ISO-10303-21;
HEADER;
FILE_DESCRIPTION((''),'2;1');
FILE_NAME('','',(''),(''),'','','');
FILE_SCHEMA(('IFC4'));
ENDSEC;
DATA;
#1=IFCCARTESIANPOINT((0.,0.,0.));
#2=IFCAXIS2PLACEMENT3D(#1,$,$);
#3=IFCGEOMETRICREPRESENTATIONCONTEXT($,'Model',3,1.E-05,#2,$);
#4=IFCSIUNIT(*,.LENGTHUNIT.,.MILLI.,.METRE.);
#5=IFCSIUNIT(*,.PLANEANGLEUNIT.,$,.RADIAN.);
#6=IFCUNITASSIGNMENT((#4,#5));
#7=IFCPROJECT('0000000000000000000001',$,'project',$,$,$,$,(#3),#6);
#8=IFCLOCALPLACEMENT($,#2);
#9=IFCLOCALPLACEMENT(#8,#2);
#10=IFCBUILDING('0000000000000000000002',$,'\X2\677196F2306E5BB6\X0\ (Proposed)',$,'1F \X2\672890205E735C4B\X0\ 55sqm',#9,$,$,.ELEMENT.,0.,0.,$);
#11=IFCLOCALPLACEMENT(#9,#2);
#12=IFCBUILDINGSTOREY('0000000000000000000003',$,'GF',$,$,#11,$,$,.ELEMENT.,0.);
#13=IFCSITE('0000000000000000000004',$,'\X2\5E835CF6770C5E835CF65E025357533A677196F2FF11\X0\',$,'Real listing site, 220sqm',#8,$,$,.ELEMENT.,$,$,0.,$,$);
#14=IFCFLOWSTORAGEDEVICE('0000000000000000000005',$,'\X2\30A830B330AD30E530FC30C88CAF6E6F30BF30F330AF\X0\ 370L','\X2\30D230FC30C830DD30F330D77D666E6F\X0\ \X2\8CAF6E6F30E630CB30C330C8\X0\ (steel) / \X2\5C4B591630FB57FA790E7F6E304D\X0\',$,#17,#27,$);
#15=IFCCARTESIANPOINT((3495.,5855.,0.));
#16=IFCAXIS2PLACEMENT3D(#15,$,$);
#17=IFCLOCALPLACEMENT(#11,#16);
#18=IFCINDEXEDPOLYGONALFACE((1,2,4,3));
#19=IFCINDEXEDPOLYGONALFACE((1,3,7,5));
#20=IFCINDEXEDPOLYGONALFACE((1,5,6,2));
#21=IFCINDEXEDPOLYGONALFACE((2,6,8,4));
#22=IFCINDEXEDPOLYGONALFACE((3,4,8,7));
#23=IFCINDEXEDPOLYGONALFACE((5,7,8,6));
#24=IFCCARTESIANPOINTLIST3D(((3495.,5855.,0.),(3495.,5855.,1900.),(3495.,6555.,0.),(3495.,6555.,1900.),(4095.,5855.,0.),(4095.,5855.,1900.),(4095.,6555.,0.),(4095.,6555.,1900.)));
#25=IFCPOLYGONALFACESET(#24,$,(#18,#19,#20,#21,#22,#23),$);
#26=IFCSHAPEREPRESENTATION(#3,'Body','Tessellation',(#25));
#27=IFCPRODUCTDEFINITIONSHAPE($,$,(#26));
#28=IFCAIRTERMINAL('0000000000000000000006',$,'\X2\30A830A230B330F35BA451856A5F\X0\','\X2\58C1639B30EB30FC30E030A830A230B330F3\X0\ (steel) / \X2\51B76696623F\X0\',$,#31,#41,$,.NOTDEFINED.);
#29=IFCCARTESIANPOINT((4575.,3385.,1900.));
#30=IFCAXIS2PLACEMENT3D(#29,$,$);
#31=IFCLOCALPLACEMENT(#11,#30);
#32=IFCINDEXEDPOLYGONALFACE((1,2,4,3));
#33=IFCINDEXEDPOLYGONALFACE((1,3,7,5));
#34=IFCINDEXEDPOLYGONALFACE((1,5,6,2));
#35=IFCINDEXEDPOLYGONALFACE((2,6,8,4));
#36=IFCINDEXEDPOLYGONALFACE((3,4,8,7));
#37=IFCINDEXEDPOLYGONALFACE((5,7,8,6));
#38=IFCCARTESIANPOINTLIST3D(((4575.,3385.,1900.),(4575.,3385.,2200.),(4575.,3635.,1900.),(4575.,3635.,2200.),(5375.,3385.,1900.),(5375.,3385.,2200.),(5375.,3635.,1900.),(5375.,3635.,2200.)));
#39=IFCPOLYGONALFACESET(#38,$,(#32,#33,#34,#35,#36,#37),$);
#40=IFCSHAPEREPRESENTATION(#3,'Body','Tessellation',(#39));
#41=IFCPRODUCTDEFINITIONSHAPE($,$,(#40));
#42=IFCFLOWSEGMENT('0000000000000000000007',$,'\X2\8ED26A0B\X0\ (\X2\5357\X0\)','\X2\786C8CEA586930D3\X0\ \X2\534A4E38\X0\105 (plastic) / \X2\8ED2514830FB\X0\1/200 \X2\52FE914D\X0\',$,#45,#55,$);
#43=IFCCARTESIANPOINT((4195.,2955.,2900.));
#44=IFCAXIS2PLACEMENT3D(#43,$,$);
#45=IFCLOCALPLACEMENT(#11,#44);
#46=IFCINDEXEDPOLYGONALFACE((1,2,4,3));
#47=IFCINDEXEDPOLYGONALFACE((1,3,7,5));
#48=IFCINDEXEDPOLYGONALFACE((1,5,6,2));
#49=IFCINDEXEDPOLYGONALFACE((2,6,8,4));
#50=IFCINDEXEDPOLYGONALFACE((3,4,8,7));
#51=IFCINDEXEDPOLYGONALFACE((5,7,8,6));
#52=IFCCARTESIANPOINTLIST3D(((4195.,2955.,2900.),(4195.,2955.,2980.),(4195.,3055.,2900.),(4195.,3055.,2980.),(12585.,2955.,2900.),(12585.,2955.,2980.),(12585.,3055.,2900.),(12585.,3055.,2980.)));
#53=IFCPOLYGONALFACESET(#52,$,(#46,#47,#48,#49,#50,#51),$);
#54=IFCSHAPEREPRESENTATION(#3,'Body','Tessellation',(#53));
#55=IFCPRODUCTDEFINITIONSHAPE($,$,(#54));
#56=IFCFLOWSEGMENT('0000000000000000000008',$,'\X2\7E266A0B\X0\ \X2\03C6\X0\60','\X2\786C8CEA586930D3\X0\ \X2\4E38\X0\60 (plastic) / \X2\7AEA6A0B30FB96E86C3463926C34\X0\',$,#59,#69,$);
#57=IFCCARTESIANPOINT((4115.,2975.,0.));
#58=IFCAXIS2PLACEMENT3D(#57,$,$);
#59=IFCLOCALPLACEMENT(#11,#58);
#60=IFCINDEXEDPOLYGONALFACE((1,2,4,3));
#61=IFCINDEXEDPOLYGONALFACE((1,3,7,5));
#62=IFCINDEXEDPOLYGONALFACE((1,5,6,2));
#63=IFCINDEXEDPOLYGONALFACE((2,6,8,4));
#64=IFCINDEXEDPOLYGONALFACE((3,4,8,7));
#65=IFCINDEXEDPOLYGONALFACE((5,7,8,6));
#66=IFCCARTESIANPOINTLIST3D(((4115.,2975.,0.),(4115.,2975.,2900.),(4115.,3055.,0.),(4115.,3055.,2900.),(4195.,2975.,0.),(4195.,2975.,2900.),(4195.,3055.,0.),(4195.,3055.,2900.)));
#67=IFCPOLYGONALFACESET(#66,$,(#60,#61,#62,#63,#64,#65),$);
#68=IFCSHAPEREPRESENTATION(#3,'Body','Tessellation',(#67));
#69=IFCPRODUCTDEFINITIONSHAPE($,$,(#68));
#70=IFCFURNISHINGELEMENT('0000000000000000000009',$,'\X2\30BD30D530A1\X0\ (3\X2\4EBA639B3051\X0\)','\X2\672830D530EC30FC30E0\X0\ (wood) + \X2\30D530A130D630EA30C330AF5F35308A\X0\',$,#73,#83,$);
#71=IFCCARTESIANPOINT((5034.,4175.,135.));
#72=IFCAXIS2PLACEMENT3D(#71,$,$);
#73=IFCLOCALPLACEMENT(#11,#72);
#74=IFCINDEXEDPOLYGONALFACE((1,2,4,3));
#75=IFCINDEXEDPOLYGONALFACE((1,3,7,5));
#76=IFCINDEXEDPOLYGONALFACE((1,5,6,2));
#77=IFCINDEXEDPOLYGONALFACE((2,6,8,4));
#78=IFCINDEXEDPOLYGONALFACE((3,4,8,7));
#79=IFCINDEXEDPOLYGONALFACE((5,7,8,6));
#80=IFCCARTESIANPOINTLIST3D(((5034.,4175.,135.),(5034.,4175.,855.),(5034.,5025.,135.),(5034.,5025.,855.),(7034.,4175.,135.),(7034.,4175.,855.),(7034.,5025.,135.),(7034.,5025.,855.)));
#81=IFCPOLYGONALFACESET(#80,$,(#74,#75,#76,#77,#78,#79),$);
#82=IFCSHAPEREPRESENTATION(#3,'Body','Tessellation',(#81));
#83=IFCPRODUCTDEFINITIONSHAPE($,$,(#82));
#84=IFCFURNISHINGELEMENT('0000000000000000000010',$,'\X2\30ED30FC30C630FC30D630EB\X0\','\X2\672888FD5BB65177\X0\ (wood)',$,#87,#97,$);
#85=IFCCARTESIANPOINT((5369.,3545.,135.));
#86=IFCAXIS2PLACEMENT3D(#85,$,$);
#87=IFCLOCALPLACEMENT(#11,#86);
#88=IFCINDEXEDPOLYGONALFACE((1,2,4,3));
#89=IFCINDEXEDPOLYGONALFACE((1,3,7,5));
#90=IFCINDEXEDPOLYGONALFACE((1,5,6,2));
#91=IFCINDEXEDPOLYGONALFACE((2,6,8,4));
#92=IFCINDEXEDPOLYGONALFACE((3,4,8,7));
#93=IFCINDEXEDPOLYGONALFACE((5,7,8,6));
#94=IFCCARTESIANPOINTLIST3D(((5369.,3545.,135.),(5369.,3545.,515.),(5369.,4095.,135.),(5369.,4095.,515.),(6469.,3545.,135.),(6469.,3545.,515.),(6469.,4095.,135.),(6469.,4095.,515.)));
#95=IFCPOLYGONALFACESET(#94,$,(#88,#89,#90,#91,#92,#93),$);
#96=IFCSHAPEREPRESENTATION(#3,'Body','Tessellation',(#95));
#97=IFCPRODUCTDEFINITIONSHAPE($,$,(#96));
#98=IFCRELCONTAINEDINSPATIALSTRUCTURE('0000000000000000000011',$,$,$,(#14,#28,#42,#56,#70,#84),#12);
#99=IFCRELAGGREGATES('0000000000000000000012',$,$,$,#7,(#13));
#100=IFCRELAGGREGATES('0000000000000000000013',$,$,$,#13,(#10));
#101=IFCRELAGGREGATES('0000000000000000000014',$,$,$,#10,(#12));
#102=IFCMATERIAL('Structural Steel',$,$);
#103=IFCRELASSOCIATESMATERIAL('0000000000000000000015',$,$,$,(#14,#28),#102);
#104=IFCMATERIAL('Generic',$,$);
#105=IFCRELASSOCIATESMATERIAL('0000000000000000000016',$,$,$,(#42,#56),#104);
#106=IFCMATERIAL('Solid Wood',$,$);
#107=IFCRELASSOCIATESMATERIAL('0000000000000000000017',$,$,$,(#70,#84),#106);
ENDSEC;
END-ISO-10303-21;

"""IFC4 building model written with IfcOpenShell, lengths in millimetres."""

from ifc_helpers import new_model, si_unit, frame, frame_2d, origin, place, context, project, spatial, rectangle, extrude, material, element, save


model = new_model("IFC4")

# Units and contexts
model_context = context("Model", 3, precision=1e-05, world=origin())
ifc_project = project(units=[si_unit("LENGTHUNIT", "METRE", prefix="MILLI"), si_unit("PLANEANGLEUNIT", "RADIAN")], contexts=[model_context])

# Site, building, storey
site_placement = place(None, origin())
site = spatial("IfcSite", under=ifc_project, at=site_placement, Name="広島県広島市南区東雲１", ObjectType="Real listing site, 220sqm", CompositionType="ELEMENT", RefElevation=0.0)
building_placement = place(site_placement, origin())
building = spatial("IfcBuilding", under=site, at=building_placement, Name="東雲の家 (Proposed)", ObjectType="1F 木造平屋 55sqm", CompositionType="ELEMENT", ElevationOfRefHeight=0.0, ElevationOfTerrain=0.0)
storey_placement = place(building_placement, origin())
storey = spatial("IfcBuildingStorey", under=building, at=storey_placement, Name="GF", CompositionType="ELEMENT", Elevation=0.0)

# Shared definitions
ifc_material_1 = material(Name="Solid Wood")

# Shared definitions
ifc_material_2 = material(Name="Structural Steel")

# Shared definitions
ifc_material_3 = material(Name="Generic")

# Flow storage device
flow_storage_device_placement = place(storey_placement, frame((3495.0, 5855.0, 0.0)))
element("IfcFlowStorageDevice", 1, at=flow_storage_device_placement, inside=storey, material=ifc_material_2, Name="エコキュート貯湯タンク 370L", Description="ヒートポンプ給湯 貯湯ユニット (steel) / 屋外・基礎置き", context=model_context, shape_type="SweptSolid", body=[
    extrude(rectangle(XDim=600.0, YDim=700.0, at=frame_2d((300.0, 350.0))), frame((3495.0, 5855.0, 0.0)), (0.0, 0.0, 1.0), 1900.0),
])

# Air terminal
air_terminal_placement = place(storey_placement, frame((4575.0, 3385.0, 1900.0)))
element("IfcAirTerminal", 2, at=air_terminal_placement, inside=storey, material=ifc_material_2, Name="エアコン室内機", Description="壁掛ルームエアコン (steel) / 冷暖房", PredefinedType="NOTDEFINED", context=model_context, shape_type="SweptSolid", body=[
    extrude(rectangle(XDim=800.0, YDim=250.0, at=frame_2d((400.0, 125.0))), frame((4575.0, 3385.0, 1900.0)), (0.0, 0.0, 1.0), 300.0),
])

# Flow segments
flow_segment_1_placement = place(storey_placement, frame((4195.0, 2955.0, 2900.0)))
element("IfcFlowSegment", 3, at=flow_segment_1_placement, inside=storey, material=ifc_material_3, Name="軒樋 (南)", Description="硬質塩ビ 半丸105 (plastic) / 軒先・1/200 勾配", context=model_context, shape_type="SweptSolid", body=[
    extrude(rectangle(XDim=8390.0, YDim=100.0, at=frame_2d((4195.0, 50.0))), frame((4195.0, 2955.0, 2900.0)), (0.0, 0.0, 1.0), 80.0),
])
flow_segment_2_placement = place(storey_placement, frame((4115.0, 2975.0, 0.0)))
element("IfcFlowSegment", 4, at=flow_segment_2_placement, inside=storey, material=ifc_material_3, Name="縦樋 φ60", Description="硬質塩ビ 丸60 (plastic) / 竪樋・雨水排水", context=model_context, shape_type="SweptSolid", body=[
    extrude(rectangle(XDim=80.0, YDim=80.0, at=frame_2d((40.0, 40.0))), frame((4115.0, 2975.0, 0.0)), (0.0, 0.0, 1.0), 2900.0),
])

# Furnishing elements
furnishing_1_placement = place(storey_placement, frame((5034.0, 4175.0, 135.0)))
element("IfcFurnishingElement", 5, at=furnishing_1_placement, inside=storey, material=ifc_material_1, Name="ソファ (3人掛け)", Description="木フレーム (wood) + ファブリック張り", context=model_context, shape_type="SweptSolid", body=[
    extrude(rectangle(XDim=2000.0, YDim=850.0, at=frame_2d((1000.0, 425.0))), frame((5034.0, 4175.0, 135.0)), (0.0, 0.0, 1.0), 720.0),
])
furnishing_2_placement = place(storey_placement, frame((5369.0, 3545.0, 135.0)))
element("IfcFurnishingElement", 6, at=furnishing_2_placement, inside=storey, material=ifc_material_1, Name="ローテーブル", Description="木製家具 (wood)", context=model_context, shape_type="SweptSolid", body=[
    extrude(rectangle(XDim=1100.0, YDim=550.0, at=frame_2d((550.0, 275.0))), frame((5369.0, 3545.0, 135.0)), (0.0, 0.0, 1.0), 380.0),
])

save(model, "model.ifc")
